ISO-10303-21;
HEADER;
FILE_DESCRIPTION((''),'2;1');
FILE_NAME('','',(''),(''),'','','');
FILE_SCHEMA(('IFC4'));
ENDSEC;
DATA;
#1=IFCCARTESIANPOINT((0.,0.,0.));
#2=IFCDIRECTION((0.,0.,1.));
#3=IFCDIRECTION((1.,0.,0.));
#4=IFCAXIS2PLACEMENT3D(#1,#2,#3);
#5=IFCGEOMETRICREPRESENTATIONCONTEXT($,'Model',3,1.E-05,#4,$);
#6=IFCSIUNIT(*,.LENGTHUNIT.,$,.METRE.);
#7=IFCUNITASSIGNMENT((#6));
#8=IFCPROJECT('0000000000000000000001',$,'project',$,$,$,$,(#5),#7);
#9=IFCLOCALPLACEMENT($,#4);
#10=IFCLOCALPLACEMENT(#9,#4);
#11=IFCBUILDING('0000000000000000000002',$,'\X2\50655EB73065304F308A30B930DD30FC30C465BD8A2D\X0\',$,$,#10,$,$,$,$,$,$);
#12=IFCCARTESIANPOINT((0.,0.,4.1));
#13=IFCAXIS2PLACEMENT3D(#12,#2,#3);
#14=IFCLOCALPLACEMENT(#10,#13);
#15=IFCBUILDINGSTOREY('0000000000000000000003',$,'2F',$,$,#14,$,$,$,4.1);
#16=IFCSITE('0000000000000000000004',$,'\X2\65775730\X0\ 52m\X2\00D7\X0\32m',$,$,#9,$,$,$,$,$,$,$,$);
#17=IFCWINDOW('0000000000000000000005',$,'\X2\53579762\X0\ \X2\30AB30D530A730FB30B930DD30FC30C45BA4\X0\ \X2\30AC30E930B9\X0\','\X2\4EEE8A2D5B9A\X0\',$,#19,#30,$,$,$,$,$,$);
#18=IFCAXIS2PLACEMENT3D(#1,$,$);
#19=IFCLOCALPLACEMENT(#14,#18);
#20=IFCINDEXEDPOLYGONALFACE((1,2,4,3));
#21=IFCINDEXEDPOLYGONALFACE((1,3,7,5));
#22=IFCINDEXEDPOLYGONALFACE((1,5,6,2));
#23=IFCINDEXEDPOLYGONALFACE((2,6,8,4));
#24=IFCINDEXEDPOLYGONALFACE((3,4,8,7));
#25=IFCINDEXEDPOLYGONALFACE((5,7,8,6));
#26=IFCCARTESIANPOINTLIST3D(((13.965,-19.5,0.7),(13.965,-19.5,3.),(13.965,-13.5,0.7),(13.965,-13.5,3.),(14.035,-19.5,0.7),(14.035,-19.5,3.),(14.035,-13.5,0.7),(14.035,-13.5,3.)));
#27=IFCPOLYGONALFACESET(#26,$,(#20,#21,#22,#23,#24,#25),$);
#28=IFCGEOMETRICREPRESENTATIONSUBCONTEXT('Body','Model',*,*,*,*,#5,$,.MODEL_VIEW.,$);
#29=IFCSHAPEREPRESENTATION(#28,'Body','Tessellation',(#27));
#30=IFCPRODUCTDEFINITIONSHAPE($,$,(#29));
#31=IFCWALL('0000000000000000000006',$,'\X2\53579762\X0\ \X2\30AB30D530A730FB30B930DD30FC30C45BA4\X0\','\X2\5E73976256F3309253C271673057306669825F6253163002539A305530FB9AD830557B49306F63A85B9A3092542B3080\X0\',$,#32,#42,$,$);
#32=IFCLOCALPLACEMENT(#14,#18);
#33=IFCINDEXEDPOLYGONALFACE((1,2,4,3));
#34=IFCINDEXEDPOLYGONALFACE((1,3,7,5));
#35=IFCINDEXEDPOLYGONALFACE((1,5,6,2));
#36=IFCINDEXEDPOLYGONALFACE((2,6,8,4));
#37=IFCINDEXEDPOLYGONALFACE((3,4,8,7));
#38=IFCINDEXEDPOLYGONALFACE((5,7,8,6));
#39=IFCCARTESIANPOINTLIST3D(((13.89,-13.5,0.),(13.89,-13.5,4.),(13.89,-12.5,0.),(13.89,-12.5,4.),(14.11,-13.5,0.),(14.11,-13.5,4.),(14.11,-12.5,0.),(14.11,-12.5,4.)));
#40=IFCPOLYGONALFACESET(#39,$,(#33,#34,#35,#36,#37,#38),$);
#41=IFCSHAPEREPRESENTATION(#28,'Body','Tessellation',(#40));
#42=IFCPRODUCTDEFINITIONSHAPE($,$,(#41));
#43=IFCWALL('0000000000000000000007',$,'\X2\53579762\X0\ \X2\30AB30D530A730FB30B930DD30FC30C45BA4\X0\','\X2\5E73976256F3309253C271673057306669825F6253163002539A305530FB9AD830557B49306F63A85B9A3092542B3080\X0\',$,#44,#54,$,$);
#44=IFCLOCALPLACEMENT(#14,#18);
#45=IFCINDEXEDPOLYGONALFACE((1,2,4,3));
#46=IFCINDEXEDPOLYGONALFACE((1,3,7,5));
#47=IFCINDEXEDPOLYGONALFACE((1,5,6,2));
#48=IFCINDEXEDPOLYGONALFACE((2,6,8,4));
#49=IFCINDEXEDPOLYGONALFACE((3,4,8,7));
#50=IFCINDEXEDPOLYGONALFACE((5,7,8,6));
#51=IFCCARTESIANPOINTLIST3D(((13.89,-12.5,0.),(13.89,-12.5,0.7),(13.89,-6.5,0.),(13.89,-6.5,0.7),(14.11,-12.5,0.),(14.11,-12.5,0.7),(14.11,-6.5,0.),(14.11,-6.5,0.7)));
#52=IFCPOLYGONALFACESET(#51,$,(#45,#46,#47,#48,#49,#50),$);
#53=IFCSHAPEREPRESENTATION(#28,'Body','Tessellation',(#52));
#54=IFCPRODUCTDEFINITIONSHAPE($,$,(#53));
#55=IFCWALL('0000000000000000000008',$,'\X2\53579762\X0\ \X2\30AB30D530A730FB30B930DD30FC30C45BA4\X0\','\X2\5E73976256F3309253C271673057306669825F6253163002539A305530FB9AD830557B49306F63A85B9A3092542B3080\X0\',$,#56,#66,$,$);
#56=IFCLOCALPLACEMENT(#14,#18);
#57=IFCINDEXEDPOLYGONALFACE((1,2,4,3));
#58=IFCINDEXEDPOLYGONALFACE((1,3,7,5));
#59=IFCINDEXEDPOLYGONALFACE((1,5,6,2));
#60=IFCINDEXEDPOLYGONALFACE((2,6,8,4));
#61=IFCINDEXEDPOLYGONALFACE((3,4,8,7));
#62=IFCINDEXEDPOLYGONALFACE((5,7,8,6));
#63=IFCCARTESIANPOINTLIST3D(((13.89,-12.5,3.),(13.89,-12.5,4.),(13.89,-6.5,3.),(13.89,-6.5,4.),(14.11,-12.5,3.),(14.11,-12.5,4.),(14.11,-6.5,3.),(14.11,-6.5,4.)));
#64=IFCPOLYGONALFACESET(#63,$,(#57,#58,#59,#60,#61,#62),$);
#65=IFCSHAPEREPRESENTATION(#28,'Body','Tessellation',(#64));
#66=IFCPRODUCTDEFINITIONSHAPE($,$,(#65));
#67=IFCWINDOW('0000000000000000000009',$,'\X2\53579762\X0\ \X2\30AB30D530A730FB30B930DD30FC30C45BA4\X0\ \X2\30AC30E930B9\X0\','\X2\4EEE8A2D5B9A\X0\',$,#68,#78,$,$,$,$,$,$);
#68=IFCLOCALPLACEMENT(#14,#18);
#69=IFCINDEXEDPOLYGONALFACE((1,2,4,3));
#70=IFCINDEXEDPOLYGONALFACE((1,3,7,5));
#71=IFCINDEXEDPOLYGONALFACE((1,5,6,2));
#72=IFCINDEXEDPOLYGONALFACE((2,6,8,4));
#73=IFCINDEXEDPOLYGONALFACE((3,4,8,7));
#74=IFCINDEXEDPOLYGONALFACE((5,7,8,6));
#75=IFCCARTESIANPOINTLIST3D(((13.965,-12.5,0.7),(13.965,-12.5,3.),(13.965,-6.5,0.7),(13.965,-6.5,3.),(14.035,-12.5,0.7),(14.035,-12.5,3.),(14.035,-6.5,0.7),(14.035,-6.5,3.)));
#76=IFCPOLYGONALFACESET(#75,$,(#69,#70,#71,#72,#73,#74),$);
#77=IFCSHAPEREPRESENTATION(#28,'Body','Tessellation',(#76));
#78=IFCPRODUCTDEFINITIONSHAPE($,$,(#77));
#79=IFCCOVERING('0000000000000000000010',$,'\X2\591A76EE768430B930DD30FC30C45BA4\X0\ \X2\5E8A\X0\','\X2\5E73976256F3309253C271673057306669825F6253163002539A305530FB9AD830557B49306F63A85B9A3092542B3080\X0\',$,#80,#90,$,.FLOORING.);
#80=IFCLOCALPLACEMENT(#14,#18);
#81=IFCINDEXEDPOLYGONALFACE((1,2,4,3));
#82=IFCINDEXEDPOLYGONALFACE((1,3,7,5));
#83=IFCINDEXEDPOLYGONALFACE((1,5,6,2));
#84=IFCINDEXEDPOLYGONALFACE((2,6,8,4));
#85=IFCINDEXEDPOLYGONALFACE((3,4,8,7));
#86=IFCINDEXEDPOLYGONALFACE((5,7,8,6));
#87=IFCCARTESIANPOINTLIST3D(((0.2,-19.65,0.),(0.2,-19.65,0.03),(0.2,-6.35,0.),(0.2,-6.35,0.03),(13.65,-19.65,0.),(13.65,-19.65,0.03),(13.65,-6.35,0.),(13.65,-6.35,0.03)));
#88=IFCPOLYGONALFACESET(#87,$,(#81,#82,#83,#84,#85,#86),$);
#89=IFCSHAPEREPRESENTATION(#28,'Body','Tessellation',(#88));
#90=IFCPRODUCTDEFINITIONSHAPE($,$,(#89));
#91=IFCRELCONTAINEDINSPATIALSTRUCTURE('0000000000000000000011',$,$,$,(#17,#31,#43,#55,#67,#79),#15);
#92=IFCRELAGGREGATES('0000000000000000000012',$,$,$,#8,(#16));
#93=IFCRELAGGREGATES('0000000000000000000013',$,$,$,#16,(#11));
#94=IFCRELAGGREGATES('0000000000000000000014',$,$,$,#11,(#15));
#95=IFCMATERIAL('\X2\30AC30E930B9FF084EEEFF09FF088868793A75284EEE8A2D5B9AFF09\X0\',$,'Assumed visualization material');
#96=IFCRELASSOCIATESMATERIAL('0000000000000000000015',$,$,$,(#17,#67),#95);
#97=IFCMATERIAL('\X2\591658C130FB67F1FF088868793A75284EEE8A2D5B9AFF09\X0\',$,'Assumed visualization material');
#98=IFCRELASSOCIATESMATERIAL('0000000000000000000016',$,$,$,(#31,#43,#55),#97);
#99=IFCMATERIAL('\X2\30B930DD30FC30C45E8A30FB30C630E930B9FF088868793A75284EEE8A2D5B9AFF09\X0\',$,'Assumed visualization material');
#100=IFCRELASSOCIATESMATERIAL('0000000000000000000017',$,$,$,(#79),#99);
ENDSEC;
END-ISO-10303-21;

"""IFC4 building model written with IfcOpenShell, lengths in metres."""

from ifc_helpers import new_model, si_unit, frame, origin_with_axes, place, context, subcontext, project, spatial, rectangle, extrude, material, element, save


model = new_model("IFC4")

# Units and contexts
model_context = context("Model", 3, precision=1e-05, world=origin_with_axes())
body_context = subcontext(model_context, "Body", "Model", "MODEL_VIEW")
ifc_project = project(units=[si_unit("LENGTHUNIT", "METRE")], contexts=[model_context])

# Site, building, storey
site_placement = place(None, origin_with_axes())
site = spatial("IfcSite", under=ifc_project, at=site_placement, Name="敷地 52m×32m")
building_placement = place(site_placement, origin_with_axes())
building = spatial("IfcBuilding", under=site, at=building_placement, Name="健康づくりスポーツ施設")
storey_placement = place(building_placement, frame((0.0, 0.0, 4.1), z_axis=(0.0, 0.0, 1.0), x_axis=(1.0, 0.0, 0.0)))
storey = spatial("IfcBuildingStorey", under=building, at=storey_placement, Name="2F", Elevation=4.1)

# Shared definitions
ifc_material_1 = material(Name="外壁・柱（表示用仮設定）", Category="Assumed visualization material")

# Window
ifc_material_2 = material(Name="ガラス（仮）（表示用仮設定）", Category="Assumed visualization material")
window_1_placement = place(storey_placement, frame((14.0, -16.5, 0.7), z_axis=(0.0, 0.0, 1.0), x_axis=(1.0, 0.0, 0.0)))
element("IfcWindow", 1, at=window_1_placement, inside=storey, material=ifc_material_2, Name="南面 カフェ・スポーツ室 ガラス", Description="仮設定", context=body_context, shape_type="SweptSolid", body=[
    extrude(rectangle(XDim=0.07, YDim=6.0), origin_with_axes(), (0.0, 0.0, 1.0), 2.3),
])

# Walls
wall_1_placement = place(storey_placement, frame((14.0, -13.0, 0.0), z_axis=(0.0, 0.0, 1.0), x_axis=(1.0, 0.0, 0.0)))
element("IfcWall", 2, at=wall_1_placement, inside=storey, material=ifc_material_1, Name="南面 カフェ・スポーツ室", Description="平面図を参照して概形化。厚さ・高さ等は推定を含む", context=body_context, shape_type="SweptSolid", body=[
    extrude(rectangle(XDim=0.22, YDim=1.0), origin_with_axes(), (0.0, 0.0, 1.0), 4.0),
])
wall_2_placement = place(storey_placement, frame((14.0, -9.5, 0.0), z_axis=(0.0, 0.0, 1.0), x_axis=(1.0, 0.0, 0.0)))
element("IfcWall", 3, at=wall_2_placement, inside=storey, material=ifc_material_1, Name="南面 カフェ・スポーツ室", Description="平面図を参照して概形化。厚さ・高さ等は推定を含む", context=body_context, shape_type="SweptSolid", body=[
    extrude(rectangle(XDim=0.22, YDim=6.0), origin_with_axes(), (0.0, 0.0, 1.0), 0.7),
])
wall_3_placement = place(storey_placement, frame((14.0, -9.5, 3.0), z_axis=(0.0, 0.0, 1.0), x_axis=(1.0, 0.0, 0.0)))
element("IfcWall", 4, at=wall_3_placement, inside=storey, material=ifc_material_1, Name="南面 カフェ・スポーツ室", Description="平面図を参照して概形化。厚さ・高さ等は推定を含む", context=body_context, shape_type="SweptSolid", body=[
    extrude(rectangle(XDim=0.22, YDim=6.0), origin_with_axes(), (0.0, 0.0, 1.0), 1.0),
])

# Window
window_2_placement = place(storey_placement, frame((14.0, -9.5, 0.7), z_axis=(0.0, 0.0, 1.0), x_axis=(1.0, 0.0, 0.0)))
element("IfcWindow", 5, at=window_2_placement, inside=storey, material=ifc_material_2, Name="南面 カフェ・スポーツ室 ガラス", Description="仮設定", context=body_context, shape_type="SweptSolid", body=[
    extrude(rectangle(XDim=0.07, YDim=6.0), origin_with_axes(), (0.0, 0.0, 1.0), 2.3),
])

# Covering
ifc_material_3 = material(Name="スポーツ床・テラス（表示用仮設定）", Category="Assumed visualization material")
covering_placement = place(storey_placement, frame((6.925, -13.0, 0.0), z_axis=(0.0, 0.0, 1.0), x_axis=(1.0, 0.0, 0.0)))
element("IfcCovering", 6, at=covering_placement, inside=storey, material=ifc_material_3, Name="多目的スポーツ室 床", Description="平面図を参照して概形化。厚さ・高さ等は推定を含む", PredefinedType="FLOORING", context=body_context, shape_type="SweptSolid", body=[
    extrude(rectangle(XDim=13.45, YDim=13.3), origin_with_axes(), (0.0, 0.0, 1.0), 0.03),
])

save(model, "model.ifc")
